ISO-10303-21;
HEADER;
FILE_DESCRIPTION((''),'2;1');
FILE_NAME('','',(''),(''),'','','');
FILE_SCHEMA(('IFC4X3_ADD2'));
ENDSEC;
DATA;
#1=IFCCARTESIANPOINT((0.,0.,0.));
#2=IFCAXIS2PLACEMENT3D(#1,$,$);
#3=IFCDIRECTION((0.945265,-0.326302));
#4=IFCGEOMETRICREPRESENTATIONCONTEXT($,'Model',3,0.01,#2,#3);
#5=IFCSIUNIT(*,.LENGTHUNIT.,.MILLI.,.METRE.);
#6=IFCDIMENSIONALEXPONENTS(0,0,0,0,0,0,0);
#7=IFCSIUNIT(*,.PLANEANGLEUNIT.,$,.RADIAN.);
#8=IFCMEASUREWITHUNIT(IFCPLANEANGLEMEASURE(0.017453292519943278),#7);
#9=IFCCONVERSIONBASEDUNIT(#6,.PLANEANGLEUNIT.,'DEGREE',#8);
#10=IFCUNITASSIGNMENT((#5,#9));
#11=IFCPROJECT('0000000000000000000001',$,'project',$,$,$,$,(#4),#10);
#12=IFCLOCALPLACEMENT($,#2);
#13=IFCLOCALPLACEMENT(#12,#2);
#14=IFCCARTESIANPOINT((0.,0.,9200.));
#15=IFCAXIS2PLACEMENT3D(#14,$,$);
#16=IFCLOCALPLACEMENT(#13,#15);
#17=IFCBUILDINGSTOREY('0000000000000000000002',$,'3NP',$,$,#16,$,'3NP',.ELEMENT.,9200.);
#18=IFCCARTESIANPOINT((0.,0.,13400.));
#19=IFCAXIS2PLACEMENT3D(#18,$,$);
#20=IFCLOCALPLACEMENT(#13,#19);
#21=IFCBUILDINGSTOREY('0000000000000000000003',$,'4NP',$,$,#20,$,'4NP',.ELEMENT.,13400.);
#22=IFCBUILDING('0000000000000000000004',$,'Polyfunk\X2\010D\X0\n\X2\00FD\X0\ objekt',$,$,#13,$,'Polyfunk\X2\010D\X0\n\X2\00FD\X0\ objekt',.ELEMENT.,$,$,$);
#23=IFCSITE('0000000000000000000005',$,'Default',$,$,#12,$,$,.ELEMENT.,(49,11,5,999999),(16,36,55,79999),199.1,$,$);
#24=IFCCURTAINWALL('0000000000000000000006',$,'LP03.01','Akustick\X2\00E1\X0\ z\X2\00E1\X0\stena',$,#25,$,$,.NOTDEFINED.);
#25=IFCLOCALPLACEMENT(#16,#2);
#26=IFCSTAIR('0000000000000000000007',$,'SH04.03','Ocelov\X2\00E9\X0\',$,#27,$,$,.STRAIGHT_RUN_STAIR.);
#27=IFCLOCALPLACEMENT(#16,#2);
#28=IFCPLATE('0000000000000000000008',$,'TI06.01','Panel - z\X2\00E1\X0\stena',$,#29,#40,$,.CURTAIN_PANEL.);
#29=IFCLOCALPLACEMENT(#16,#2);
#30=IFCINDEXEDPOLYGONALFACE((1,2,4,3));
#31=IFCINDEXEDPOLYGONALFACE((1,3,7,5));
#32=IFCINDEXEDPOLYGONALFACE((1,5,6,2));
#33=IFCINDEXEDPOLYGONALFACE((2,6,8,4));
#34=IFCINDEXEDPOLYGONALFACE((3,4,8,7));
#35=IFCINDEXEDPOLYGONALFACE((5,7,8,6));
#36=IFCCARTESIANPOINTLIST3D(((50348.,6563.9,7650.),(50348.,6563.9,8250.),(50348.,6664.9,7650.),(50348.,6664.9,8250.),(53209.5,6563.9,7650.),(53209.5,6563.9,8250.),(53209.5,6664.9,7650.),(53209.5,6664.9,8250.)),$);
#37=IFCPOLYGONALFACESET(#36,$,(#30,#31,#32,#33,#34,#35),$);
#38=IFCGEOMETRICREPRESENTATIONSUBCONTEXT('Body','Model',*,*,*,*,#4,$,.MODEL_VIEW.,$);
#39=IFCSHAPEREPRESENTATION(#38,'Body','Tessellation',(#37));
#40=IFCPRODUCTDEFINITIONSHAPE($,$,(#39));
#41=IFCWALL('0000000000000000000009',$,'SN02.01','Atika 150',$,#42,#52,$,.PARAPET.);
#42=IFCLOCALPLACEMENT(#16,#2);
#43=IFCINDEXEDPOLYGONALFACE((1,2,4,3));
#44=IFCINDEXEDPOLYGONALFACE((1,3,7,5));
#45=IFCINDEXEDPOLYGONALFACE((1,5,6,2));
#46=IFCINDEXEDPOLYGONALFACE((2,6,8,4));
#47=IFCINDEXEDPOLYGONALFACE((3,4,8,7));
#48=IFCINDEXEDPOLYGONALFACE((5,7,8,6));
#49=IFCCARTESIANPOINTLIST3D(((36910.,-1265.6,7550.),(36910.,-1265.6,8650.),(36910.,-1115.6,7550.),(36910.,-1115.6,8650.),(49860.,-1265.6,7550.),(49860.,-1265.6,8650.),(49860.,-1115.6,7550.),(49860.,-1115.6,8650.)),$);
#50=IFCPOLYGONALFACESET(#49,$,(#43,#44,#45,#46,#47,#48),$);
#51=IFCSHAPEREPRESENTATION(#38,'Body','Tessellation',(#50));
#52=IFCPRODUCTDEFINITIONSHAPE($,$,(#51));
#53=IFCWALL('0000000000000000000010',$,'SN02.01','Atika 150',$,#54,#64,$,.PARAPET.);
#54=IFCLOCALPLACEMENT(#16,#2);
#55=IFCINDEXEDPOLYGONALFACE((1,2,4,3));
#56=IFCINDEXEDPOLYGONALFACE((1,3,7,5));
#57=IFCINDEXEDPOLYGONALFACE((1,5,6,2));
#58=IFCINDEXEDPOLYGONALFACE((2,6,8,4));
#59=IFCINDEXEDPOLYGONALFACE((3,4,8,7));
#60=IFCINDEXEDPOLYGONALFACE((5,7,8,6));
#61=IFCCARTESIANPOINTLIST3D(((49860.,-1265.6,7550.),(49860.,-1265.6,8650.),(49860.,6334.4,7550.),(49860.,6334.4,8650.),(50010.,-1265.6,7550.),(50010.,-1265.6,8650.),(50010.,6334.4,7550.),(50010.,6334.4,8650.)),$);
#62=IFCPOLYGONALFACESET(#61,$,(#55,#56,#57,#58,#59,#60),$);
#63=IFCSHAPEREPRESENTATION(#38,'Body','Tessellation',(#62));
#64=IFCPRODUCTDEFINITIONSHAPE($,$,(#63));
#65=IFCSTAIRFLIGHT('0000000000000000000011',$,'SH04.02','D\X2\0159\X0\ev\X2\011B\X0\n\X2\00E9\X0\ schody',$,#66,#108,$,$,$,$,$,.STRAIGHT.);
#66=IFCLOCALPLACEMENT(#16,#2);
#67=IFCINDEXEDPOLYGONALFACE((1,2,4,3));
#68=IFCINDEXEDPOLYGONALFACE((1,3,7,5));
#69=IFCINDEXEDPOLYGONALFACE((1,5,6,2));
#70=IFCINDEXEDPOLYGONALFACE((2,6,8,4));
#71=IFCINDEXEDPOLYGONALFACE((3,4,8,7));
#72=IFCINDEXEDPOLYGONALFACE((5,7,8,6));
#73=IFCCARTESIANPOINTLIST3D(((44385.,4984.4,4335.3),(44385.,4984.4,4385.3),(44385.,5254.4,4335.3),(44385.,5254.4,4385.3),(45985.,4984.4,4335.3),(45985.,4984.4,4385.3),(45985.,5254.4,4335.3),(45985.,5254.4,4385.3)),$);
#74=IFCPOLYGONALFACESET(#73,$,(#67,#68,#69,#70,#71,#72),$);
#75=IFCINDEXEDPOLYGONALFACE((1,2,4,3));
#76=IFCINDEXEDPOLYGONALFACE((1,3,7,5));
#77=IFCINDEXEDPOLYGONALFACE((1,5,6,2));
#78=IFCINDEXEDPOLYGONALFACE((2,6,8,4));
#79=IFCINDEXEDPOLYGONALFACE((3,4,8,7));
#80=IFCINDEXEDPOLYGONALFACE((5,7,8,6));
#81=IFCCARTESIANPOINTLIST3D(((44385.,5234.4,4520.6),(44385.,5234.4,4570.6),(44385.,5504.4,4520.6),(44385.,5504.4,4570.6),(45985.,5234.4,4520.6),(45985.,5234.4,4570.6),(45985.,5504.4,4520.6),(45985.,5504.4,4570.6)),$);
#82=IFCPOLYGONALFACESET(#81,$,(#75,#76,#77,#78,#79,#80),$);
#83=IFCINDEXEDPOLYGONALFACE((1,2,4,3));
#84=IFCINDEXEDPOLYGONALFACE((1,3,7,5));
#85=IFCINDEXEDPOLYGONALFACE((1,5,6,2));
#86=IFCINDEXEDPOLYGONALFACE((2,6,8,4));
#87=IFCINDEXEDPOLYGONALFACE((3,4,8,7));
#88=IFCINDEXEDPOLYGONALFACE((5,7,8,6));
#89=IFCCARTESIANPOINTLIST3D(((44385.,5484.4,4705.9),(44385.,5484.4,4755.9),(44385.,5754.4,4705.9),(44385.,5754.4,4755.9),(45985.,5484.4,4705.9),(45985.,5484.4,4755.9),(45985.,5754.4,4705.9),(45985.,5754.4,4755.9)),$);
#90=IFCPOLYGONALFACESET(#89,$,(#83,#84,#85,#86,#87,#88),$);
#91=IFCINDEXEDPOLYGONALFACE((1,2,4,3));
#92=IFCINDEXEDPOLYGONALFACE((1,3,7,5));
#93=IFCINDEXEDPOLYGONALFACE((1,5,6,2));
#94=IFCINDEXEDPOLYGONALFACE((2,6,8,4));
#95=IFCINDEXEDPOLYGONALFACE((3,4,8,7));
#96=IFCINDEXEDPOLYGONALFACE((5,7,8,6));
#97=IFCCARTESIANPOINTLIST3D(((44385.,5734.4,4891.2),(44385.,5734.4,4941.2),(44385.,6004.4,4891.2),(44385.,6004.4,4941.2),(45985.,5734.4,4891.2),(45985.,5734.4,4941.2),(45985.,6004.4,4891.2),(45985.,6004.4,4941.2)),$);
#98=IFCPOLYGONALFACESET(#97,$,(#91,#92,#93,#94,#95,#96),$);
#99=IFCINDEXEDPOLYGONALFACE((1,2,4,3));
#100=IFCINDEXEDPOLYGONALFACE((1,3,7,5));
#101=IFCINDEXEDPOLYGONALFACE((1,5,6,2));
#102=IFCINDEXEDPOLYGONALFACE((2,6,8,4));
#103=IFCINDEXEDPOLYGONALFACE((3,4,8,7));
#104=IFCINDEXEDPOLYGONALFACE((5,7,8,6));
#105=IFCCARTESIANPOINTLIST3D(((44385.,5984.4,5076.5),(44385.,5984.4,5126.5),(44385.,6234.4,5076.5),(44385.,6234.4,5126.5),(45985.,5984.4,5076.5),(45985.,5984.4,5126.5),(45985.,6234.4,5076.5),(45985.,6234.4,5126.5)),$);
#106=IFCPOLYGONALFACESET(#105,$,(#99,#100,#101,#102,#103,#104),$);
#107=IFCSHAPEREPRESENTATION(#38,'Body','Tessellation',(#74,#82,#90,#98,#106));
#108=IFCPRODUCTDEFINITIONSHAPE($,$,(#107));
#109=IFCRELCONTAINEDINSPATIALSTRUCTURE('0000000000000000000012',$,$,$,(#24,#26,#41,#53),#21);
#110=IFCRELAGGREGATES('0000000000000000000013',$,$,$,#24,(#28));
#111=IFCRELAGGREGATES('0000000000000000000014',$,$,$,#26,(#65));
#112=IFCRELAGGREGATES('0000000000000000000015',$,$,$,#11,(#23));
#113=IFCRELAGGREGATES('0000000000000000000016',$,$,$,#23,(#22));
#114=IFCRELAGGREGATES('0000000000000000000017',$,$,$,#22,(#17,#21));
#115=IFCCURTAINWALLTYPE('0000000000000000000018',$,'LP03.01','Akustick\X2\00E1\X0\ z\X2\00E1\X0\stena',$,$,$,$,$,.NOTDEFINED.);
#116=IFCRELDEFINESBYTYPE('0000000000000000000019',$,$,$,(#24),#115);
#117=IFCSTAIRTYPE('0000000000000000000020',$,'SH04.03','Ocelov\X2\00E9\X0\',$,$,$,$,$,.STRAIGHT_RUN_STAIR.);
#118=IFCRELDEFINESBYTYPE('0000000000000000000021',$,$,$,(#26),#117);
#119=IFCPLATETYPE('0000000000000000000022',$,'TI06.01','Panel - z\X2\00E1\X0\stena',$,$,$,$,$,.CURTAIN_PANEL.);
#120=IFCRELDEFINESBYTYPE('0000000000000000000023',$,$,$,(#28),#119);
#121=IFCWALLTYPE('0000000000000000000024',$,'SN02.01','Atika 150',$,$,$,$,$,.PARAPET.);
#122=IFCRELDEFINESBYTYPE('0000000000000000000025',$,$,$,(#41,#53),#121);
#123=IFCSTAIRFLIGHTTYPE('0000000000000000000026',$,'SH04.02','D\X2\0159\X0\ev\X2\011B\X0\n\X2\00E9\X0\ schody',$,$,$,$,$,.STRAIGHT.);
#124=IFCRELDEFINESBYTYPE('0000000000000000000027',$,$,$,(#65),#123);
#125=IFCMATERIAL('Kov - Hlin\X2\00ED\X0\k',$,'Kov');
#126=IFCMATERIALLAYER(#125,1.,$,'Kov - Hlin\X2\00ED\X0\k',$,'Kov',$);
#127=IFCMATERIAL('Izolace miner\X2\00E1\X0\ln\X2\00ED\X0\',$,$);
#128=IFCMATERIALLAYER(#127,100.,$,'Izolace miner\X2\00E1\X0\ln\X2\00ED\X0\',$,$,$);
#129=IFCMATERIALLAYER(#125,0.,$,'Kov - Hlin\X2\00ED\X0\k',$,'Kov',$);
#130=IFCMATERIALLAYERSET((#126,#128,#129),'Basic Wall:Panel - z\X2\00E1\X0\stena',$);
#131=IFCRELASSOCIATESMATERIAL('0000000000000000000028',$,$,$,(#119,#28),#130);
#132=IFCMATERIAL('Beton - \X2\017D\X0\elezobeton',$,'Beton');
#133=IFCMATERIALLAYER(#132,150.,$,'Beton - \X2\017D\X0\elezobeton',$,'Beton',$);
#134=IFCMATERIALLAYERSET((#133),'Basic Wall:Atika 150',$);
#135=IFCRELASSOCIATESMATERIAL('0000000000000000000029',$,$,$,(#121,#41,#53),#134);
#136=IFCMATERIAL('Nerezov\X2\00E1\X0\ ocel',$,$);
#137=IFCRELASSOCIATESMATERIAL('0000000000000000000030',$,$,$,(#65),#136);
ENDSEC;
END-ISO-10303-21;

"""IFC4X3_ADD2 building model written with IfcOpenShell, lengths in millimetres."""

from ifc_helpers import new_model, entity, si_unit, converted_unit, direction, frame, frame_2d, origin, origin_2d_with_axis, place, context, subcontext, project, spatial, rectangle, extrude, material, layer, layer_set, layer_usage, type_object, element, aggregate, save


model = new_model("IFC4X3_ADD2")

# Units and contexts
model_context = context("Model", 3, precision=0.01, world=origin(), true_north=direction((0.945265, -0.326302)))
body_context = subcontext(model_context, "Body", "Model", "MODEL_VIEW")
ifc_project = project(units=[si_unit("LENGTHUNIT", "METRE", prefix="MILLI"), converted_unit("PLANEANGLEUNIT", "DEGREE", entity("IfcPlaneAngleMeasure", 0.017453292519943278), si_unit("PLANEANGLEUNIT", "RADIAN"), dimensions=[0, 0, 0, 0, 0, 0, 0])], contexts=[model_context])

# Site, building, storey
site_placement = place(None, origin())
site = spatial("IfcSite", under=ifc_project, at=site_placement, Name="Default", CompositionType="ELEMENT", RefLatitude=(49, 11, 5, 999999), RefLongitude=(16, 36, 55, 79999), RefElevation=199.1)
building_placement = place(site_placement, origin())
building = spatial("IfcBuilding", under=site, at=building_placement, Name="Polyfunkčný objekt", LongName="Polyfunkčný objekt", CompositionType="ELEMENT")
storey_1_placement = place(building_placement, frame((0.0, 0.0, 9200.0)))
storey_1 = spatial("IfcBuildingStorey", under=building, at=storey_1_placement, Name="3NP", LongName="3NP", CompositionType="ELEMENT", Elevation=9200.0)

# Shared definitions
storey_2_placement = place(building_placement, frame((0.0, 0.0, 13400.0)))
storey_2 = spatial("IfcBuildingStorey", under=building, at=storey_2_placement, Name="4NP", LongName="4NP", CompositionType="ELEMENT", Elevation=13400.0)

# Curtain wall
curtain_wall_type_1 = type_object("IfcCurtainWallType", Name="LP03.01", Description="Akustická zástena", PredefinedType="NOTDEFINED")
curtain_wall_1_placement = place(storey_2_placement, frame((0.0, 0.0, -13400.0)))
curtain_wall_1 = element("IfcCurtainWall", 1, at=curtain_wall_1_placement, inside=storey_2, type_object=curtain_wall_type_1, Name="LP03.01", Description="Akustická zástena", PredefinedType="NOTDEFINED")
ifc_material_1 = material(Name="Nerezová ocel")

# Stair
stair_type = type_object("IfcStairType", Name="SH04.03", Description="Ocelové", PredefinedType="STRAIGHT_RUN_STAIR")
stair_placement = place(storey_2_placement, origin())
stair = element("IfcStair", 2, at=stair_placement, inside=storey_2, type_object=stair_type, Name="SH04.03", Description="Ocelové", PredefinedType="STRAIGHT_RUN_STAIR")

# Plate
ifc_material_2 = material(Name="Kov - Hliník", Category="Kov")
ifc_layer_1 = layer(ifc_material_2, 1.0, Name="Kov - Hliník", Category="Kov")
ifc_material_3 = material(Name="Izolace minerální")
ifc_layer_2 = layer(ifc_material_3, 100.0, Name="Izolace minerální")
ifc_layer_3 = layer(ifc_material_2, 0.0, Name="Kov - Hliník", Category="Kov")
ifc_layer_set_1 = layer_set([ifc_layer_1, ifc_layer_2, ifc_layer_3], Name="Basic Wall:Panel - zástena")
plate_type = type_object("IfcPlateType", Name="TI06.01", Description="Panel - zástena", PredefinedType="CURTAIN_PANEL", material=ifc_layer_set_1)
ifc_layer_usage_1 = layer_usage(ifc_layer_set_1, "AXIS2", "POSITIVE", -50.5)
plate_1_placement = place(storey_2_placement, frame((50348.0, 6614.4, 3450.0)))
plate_1 = element("IfcPlate", 3, at=plate_1_placement, type_object=plate_type, material=ifc_layer_usage_1, Name="TI06.01", Description="Panel - zástena", PredefinedType="CURTAIN_PANEL", context=body_context, shape_type="SweptSolid", body=[
    extrude(rectangle(XDim=101.0, YDim=2861.5, at=frame_2d((0.0, 0.0), x_axis=(1.0, 0.0))), frame((1430.7, 0.0, 0.0), z_axis=(0.0, 0.0, 1.0), x_axis=(0.0, 1.0, 0.0)), (0.0, 0.0, 1.0), 600.0),
])
aggregate(curtain_wall_1, [plate_1])

# Walls
ifc_material_4 = material(Name="Beton - Železobeton", Category="Beton")
ifc_layer_4 = layer(ifc_material_4, 150.0, Name="Beton - Železobeton", Category="Beton")
ifc_layer_set_2 = layer_set([ifc_layer_4], Name="Basic Wall:Atika 150")
wall_type = type_object("IfcWallType", Name="SN02.01", Description="Atika 150", PredefinedType="PARAPET", material=ifc_layer_set_2)
wall_1_placement = place(storey_2_placement, frame((49860.0, -1190.6, 3350.0), z_axis=(0.0, 0.0, 1.0), x_axis=(-1.0, 0.0, 0.0)))
element("IfcWall", 4, at=wall_1_placement, inside=storey_2, type_object=wall_type, material=ifc_layer_set_2, Name="SN02.01", Description="Atika 150", PredefinedType="PARAPET", context=body_context, shape_type="SweptSolid", body=[
    extrude(rectangle(XDim=12950.0, YDim=150.0, at=frame_2d((6475.0, 0.0), x_axis=(-1.0, 0.0))), origin(), (0.0, 0.0, 1.0), 1100.0),
])
wall_2_placement = place(storey_2_placement, frame((49935.0, 6334.4, 3350.0), z_axis=(0.0, 0.0, 1.0), x_axis=(0.0, -1.0, 0.0)))
element("IfcWall", 5, at=wall_2_placement, inside=storey_2, type_object=wall_type, material=ifc_layer_set_2, Name="SN02.01", Description="Atika 150", PredefinedType="PARAPET", context=body_context, shape_type="SweptSolid", body=[
    extrude(rectangle(XDim=7600.0, YDim=150.0, at=frame_2d((3800.0, 0.0), x_axis=(-1.0, 0.0))), origin(), (0.0, 0.0, 1.0), 1100.0),
])

# Stair flight
stair_flight_type = type_object("IfcStairFlightType", Name="SH04.02", Description="Dřevěné schody", PredefinedType="STRAIGHT")
stair_flight_placement = place(stair_placement, frame((44385.0, 4984.4, 0.0)))
stair_flight = element("IfcStairFlight", 6, at=stair_flight_placement, type_object=stair_flight_type, material=ifc_material_1, Name="SH04.02", Description="Dřevěné schody", PredefinedType="STRAIGHT", context=body_context, shape_type="SweptSolid", body=[
    extrude(rectangle(XDim=270.0, YDim=1600.0, at=origin_2d_with_axis()), frame((800.0, 135.0, 135.3), z_axis=(0.0, 0.0, 1.0), x_axis=(0.0, -1.0, 0.0)), (0.0, 0.0, 1.0), 50.0),
    extrude(rectangle(XDim=270.0, YDim=1600.0, at=origin_2d_with_axis()), frame((800.0, 385.0, 320.6), z_axis=(0.0, 0.0, 1.0), x_axis=(0.0, -1.0, 0.0)), (0.0, 0.0, 1.0), 50.0),
    extrude(rectangle(XDim=270.0, YDim=1600.0, at=origin_2d_with_axis()), frame((800.0, 635.0, 505.9), z_axis=(0.0, 0.0, 1.0), x_axis=(0.0, -1.0, 0.0)), (0.0, 0.0, 1.0), 50.0),
    extrude(rectangle(XDim=270.0, YDim=1600.0, at=origin_2d_with_axis()), frame((800.0, 885.0, 691.2), z_axis=(0.0, 0.0, 1.0), x_axis=(0.0, -1.0, 0.0)), (0.0, 0.0, 1.0), 50.0),
    extrude(rectangle(XDim=250.0, YDim=1600.0, at=origin_2d_with_axis()), frame((800.0, 1125.0, 876.5), z_axis=(0.0, 0.0, 1.0), x_axis=(0.0, -1.0, 0.0)), (0.0, 0.0, 1.0), 50.0),
])
aggregate(stair, [stair_flight])

save(model, "model.ifc")
